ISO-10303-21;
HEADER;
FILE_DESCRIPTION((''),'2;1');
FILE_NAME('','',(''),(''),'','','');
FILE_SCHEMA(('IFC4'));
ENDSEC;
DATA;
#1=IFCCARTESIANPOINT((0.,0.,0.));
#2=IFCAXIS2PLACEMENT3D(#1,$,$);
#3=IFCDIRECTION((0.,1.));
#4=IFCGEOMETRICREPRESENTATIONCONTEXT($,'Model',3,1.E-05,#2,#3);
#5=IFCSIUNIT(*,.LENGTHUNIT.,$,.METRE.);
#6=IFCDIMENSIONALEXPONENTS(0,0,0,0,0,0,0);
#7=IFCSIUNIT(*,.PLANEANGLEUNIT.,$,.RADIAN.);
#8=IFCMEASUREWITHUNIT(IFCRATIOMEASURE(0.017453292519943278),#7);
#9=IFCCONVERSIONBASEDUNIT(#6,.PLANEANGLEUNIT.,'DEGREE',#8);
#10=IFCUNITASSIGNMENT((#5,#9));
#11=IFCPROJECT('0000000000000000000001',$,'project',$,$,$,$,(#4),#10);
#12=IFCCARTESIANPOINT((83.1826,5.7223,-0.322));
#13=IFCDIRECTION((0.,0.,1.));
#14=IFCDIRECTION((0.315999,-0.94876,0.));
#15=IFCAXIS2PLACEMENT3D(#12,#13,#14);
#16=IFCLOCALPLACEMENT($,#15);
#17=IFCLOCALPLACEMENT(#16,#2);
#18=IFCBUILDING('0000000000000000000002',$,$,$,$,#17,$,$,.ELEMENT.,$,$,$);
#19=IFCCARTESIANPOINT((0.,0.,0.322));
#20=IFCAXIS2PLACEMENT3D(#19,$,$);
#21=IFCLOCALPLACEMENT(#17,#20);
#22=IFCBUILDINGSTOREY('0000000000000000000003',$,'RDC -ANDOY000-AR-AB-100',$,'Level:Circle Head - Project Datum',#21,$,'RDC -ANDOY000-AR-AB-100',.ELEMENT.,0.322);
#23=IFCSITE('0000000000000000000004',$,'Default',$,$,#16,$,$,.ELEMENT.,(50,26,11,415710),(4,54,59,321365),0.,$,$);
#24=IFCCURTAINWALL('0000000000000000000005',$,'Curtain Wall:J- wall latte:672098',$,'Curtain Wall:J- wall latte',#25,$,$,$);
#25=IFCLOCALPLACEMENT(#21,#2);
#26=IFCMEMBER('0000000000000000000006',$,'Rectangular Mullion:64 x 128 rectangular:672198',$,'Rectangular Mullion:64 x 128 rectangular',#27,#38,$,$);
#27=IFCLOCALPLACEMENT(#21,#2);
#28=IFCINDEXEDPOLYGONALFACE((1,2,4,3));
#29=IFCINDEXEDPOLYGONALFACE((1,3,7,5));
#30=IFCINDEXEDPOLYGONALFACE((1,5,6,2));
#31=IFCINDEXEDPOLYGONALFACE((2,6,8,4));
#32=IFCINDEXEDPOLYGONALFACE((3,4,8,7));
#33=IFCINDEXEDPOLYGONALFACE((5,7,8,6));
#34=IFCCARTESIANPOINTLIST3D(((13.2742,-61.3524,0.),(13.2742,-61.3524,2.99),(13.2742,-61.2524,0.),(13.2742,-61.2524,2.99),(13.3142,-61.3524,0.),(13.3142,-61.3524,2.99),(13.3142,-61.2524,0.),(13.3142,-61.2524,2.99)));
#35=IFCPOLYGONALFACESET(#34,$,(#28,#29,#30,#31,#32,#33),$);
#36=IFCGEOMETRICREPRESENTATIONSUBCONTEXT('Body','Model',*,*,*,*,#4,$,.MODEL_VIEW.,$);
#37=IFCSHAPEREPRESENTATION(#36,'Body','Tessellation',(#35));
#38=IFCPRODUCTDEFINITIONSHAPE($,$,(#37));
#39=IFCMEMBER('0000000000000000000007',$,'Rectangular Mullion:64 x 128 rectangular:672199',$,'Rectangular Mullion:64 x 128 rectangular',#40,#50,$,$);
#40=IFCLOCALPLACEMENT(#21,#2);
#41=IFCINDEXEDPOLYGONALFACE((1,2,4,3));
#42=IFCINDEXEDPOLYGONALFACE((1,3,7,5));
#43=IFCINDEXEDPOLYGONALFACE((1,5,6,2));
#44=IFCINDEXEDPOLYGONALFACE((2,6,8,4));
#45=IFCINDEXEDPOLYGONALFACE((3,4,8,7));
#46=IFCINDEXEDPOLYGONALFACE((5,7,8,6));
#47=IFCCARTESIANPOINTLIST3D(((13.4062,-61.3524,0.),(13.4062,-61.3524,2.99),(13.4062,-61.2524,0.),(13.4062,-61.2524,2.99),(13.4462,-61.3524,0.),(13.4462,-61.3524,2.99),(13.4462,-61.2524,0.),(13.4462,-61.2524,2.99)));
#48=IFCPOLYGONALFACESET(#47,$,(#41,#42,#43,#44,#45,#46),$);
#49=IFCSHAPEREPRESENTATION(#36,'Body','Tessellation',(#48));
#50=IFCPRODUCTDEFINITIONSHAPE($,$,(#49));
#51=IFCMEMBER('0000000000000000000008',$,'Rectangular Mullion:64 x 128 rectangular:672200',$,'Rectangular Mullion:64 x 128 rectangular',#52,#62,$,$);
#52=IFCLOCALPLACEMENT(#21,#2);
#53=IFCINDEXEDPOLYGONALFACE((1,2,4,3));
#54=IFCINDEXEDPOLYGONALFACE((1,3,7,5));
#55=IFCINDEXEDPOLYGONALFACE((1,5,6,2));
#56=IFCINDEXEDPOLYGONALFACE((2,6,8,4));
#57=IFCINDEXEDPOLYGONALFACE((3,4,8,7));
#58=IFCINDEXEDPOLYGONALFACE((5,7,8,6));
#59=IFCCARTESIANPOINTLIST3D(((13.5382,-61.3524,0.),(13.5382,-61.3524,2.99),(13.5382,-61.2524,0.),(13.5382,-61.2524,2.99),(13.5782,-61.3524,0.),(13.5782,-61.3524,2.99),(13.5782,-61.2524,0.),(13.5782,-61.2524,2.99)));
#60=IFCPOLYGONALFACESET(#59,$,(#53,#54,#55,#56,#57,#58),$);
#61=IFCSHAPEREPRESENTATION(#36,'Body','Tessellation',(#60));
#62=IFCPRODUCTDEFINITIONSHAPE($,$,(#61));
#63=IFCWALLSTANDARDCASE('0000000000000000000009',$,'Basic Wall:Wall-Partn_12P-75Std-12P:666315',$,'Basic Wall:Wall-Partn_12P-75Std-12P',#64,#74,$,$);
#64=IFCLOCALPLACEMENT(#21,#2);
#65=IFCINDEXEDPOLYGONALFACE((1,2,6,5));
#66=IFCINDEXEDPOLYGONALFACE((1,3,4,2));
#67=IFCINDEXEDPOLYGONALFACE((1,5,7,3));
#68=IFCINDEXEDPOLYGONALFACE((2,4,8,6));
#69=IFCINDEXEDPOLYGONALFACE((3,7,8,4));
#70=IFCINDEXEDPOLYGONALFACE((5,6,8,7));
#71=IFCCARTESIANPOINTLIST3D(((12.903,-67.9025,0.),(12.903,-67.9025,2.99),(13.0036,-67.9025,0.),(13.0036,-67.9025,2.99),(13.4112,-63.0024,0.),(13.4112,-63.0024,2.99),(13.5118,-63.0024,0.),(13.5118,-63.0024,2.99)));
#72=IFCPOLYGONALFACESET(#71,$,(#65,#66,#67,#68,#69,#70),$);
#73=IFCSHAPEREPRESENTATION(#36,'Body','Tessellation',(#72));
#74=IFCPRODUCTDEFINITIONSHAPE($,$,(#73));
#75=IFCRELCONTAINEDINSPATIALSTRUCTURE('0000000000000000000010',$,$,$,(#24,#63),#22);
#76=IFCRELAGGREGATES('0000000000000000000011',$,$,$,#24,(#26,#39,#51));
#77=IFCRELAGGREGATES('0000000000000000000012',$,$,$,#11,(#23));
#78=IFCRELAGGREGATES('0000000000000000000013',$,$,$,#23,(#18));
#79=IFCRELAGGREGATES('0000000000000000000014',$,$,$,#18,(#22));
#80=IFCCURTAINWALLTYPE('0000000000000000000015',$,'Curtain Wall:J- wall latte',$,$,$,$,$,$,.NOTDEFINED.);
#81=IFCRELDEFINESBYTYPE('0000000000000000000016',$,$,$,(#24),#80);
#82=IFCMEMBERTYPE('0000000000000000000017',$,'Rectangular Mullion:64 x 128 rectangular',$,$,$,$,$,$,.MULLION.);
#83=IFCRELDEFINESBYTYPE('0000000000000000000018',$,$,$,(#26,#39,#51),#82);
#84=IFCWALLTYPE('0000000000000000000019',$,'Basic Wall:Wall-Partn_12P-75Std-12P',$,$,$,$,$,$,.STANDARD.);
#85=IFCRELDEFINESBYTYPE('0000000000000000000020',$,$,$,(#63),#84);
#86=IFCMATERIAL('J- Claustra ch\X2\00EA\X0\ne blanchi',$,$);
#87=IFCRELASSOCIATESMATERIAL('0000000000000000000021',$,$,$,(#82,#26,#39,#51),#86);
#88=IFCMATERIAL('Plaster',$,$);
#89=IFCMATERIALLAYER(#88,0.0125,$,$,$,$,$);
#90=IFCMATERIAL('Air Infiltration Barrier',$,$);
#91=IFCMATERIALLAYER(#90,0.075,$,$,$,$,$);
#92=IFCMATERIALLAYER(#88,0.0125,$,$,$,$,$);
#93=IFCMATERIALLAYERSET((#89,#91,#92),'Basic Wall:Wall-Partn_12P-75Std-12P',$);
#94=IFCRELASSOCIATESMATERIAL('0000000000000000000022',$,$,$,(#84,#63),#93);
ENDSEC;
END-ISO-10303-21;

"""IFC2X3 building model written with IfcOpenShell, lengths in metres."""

from ifc_helpers import new_model, entity, si_unit, converted_unit, direction, frame, origin, origin_2d_with_axis, place, context, subcontext, project, spatial, polyline, rectangle, outline, extrude, clip, bounded_halfspace, source, transform, mapped, material, layer, layer_set, layer_usage, type_object, type_shapes, element, aggregate, save


model = new_model("IFC2X3")

# Units and contexts
model_context = context("Model", 3, precision=1e-05, world=origin(), true_north=direction((0.0, 1.0)))
body_context = subcontext(model_context, "Body", "Model", "MODEL_VIEW")
ifc_project = project(units=[si_unit("LENGTHUNIT", "METRE"), converted_unit("PLANEANGLEUNIT", "DEGREE", entity("IfcRatioMeasure", 0.017453292519943278), si_unit("PLANEANGLEUNIT", "RADIAN"), dimensions=[0, 0, 0, 0, 0, 0, 0])], contexts=[model_context])

# Site, building, storey
site_placement = place(None, frame((83.1826, 5.7223, -0.322), z_axis=(0.0, 0.0, 1.0), x_axis=(0.315999, -0.94876, 0.0)))
site = spatial("IfcSite", under=ifc_project, at=site_placement, Name="Default", CompositionType="ELEMENT", RefLatitude=(50, 26, 11, 415710), RefLongitude=(4, 54, 59, 321365), RefElevation=0.0)
building_placement = place(site_placement, origin())
building = spatial("IfcBuilding", under=site, at=building_placement, CompositionType="ELEMENT")
storey_placement = place(building_placement, frame((0.0, 0.0, 0.322)))
storey = spatial("IfcBuildingStorey", under=building, at=storey_placement, Name="RDC -ANDOY000-AR-AB-100", ObjectType="Level:Circle Head - Project Datum", LongName="RDC -ANDOY000-AR-AB-100", CompositionType="ELEMENT", Elevation=0.322)

# Curtain wall, members
curtain_wall_type = type_object("IfcCurtainWallType", Name="Curtain Wall:J- wall latte", PredefinedType="NOTDEFINED")
ifc_material_1 = material(Name="J- Claustra chêne blanchi")
member_type = type_object("IfcMemberType", Name="Rectangular Mullion:64 x 128 rectangular", PredefinedType="MULLION", material=ifc_material_1)
shared_shape_1 = source(origin(), body_context, "Body", "SweptSolid", [
    extrude(rectangle(XDim=0.1, YDim=0.04, at=origin_2d_with_axis()), frame((0.0, 0.0, -2.99), z_axis=(0.0, 0.0, 1.0), x_axis=(0.0, -1.0, 0.0)), (0.0, 0.0, 1.0), 2.99),
])
type_shapes(member_type, [shared_shape_1])
curtain_wall_1_placement = place(storey_placement, frame((0.0, 0.0, -0.322)))
curtain_wall_1 = element("IfcCurtainWall", 1, at=curtain_wall_1_placement, inside=storey, type_object=curtain_wall_type, Name="Curtain Wall:J- wall latte:672098", ObjectType="Curtain Wall:J- wall latte")
member_1_placement = place(curtain_wall_1_placement, frame((13.2942, -61.3024, 0.322), z_axis=(0.0, 0.0, -1.0), x_axis=(1.0, 0.0, 0.0)))
member_1 = element("IfcMember", 2, at=member_1_placement, type_object=member_type, material=ifc_material_1, Name="Rectangular Mullion:64 x 128 rectangular:672198", ObjectType="Rectangular Mullion:64 x 128 rectangular", context=body_context, shape_type="MappedRepresentation", body=[
    mapped(shared_shape_1, transform((0.0, 0.0, 0.0), scale=1.0)),
])
member_2_placement = place(curtain_wall_1_placement, frame((13.4262, -61.3024, 0.322), z_axis=(0.0, 0.0, -1.0), x_axis=(1.0, 0.0, 0.0)))
member_2 = element("IfcMember", 3, at=member_2_placement, type_object=member_type, material=ifc_material_1, Name="Rectangular Mullion:64 x 128 rectangular:672199", ObjectType="Rectangular Mullion:64 x 128 rectangular", context=body_context, shape_type="MappedRepresentation", body=[
    mapped(shared_shape_1, transform((0.0, 0.0, 0.0), scale=1.0)),
])
member_3_placement = place(curtain_wall_1_placement, frame((13.5582, -61.3024, 0.322), z_axis=(0.0, 0.0, -1.0), x_axis=(1.0, 0.0, 0.0)))
member_3 = element("IfcMember", 4, at=member_3_placement, type_object=member_type, material=ifc_material_1, Name="Rectangular Mullion:64 x 128 rectangular:672200", ObjectType="Rectangular Mullion:64 x 128 rectangular", context=body_context, shape_type="MappedRepresentation", body=[
    mapped(shared_shape_1, transform((0.0, 0.0, 0.0), scale=1.0)),
])

aggregate(curtain_wall_1, [member_1, member_2, member_3])

# Wall
ifc_material_2 = material(Name="Plaster")
ifc_layer_1 = layer(ifc_material_2, 0.0125)
ifc_material_3 = material(Name="Air Infiltration Barrier")
ifc_layer_2 = layer(ifc_material_3, 0.075)
ifc_layer_3 = layer(ifc_material_2, 0.0125)
ifc_layer_set = layer_set([ifc_layer_1, ifc_layer_2, ifc_layer_3], Name="Basic Wall:Wall-Partn_12P-75Std-12P")
ifc_layer_usage = layer_usage(ifc_layer_set, "AXIS2", "NEGATIVE", 0.05)
wall_type = type_object("IfcWallType", Name="Basic Wall:Wall-Partn_12P-75Std-12P", PredefinedType="STANDARD", material=ifc_layer_set)
wall_placement = place(storey_placement, frame((13.462, -62.9972, 0.0), z_axis=(0.0, 0.0, 1.0), x_axis=(-0.103155, -0.994665, 0.0)))
element("IfcWallStandardCase", 5, at=wall_placement, inside=storey, type_object=wall_type, material=ifc_layer_usage, Name="Basic Wall:Wall-Partn_12P-75Std-12P:666315", ObjectType="Basic Wall:Wall-Partn_12P-75Std-12P", context=body_context, shape_type="Clipping", body=[
    clip(extrude(outline(polyline([(4.9368, -0.05), (4.9264, 0.05), (0.0, 0.05), (0.0104, -0.05), (2.4253, -0.05), (2.5258, -0.05), (4.9368, -0.05)])), origin(), (0.0, 0.0, 1.0), 2.99), bounded_halfspace(frame((0.0104, -0.05, 2.99), z_axis=(0.0, 0.0, -1.0), x_axis=(-0.103155, 0.994665, 0.0)), True, frame((0.0104, -0.05, 2.99)), polyline([(0.0, 0.0), (2.4149, 0.0), (2.5155, 0.0), (4.9264, 0.0), (4.916, 0.1), (-0.0104, 0.1), (0.0, 0.0)]))),
])

save(model, "model.ifc")
